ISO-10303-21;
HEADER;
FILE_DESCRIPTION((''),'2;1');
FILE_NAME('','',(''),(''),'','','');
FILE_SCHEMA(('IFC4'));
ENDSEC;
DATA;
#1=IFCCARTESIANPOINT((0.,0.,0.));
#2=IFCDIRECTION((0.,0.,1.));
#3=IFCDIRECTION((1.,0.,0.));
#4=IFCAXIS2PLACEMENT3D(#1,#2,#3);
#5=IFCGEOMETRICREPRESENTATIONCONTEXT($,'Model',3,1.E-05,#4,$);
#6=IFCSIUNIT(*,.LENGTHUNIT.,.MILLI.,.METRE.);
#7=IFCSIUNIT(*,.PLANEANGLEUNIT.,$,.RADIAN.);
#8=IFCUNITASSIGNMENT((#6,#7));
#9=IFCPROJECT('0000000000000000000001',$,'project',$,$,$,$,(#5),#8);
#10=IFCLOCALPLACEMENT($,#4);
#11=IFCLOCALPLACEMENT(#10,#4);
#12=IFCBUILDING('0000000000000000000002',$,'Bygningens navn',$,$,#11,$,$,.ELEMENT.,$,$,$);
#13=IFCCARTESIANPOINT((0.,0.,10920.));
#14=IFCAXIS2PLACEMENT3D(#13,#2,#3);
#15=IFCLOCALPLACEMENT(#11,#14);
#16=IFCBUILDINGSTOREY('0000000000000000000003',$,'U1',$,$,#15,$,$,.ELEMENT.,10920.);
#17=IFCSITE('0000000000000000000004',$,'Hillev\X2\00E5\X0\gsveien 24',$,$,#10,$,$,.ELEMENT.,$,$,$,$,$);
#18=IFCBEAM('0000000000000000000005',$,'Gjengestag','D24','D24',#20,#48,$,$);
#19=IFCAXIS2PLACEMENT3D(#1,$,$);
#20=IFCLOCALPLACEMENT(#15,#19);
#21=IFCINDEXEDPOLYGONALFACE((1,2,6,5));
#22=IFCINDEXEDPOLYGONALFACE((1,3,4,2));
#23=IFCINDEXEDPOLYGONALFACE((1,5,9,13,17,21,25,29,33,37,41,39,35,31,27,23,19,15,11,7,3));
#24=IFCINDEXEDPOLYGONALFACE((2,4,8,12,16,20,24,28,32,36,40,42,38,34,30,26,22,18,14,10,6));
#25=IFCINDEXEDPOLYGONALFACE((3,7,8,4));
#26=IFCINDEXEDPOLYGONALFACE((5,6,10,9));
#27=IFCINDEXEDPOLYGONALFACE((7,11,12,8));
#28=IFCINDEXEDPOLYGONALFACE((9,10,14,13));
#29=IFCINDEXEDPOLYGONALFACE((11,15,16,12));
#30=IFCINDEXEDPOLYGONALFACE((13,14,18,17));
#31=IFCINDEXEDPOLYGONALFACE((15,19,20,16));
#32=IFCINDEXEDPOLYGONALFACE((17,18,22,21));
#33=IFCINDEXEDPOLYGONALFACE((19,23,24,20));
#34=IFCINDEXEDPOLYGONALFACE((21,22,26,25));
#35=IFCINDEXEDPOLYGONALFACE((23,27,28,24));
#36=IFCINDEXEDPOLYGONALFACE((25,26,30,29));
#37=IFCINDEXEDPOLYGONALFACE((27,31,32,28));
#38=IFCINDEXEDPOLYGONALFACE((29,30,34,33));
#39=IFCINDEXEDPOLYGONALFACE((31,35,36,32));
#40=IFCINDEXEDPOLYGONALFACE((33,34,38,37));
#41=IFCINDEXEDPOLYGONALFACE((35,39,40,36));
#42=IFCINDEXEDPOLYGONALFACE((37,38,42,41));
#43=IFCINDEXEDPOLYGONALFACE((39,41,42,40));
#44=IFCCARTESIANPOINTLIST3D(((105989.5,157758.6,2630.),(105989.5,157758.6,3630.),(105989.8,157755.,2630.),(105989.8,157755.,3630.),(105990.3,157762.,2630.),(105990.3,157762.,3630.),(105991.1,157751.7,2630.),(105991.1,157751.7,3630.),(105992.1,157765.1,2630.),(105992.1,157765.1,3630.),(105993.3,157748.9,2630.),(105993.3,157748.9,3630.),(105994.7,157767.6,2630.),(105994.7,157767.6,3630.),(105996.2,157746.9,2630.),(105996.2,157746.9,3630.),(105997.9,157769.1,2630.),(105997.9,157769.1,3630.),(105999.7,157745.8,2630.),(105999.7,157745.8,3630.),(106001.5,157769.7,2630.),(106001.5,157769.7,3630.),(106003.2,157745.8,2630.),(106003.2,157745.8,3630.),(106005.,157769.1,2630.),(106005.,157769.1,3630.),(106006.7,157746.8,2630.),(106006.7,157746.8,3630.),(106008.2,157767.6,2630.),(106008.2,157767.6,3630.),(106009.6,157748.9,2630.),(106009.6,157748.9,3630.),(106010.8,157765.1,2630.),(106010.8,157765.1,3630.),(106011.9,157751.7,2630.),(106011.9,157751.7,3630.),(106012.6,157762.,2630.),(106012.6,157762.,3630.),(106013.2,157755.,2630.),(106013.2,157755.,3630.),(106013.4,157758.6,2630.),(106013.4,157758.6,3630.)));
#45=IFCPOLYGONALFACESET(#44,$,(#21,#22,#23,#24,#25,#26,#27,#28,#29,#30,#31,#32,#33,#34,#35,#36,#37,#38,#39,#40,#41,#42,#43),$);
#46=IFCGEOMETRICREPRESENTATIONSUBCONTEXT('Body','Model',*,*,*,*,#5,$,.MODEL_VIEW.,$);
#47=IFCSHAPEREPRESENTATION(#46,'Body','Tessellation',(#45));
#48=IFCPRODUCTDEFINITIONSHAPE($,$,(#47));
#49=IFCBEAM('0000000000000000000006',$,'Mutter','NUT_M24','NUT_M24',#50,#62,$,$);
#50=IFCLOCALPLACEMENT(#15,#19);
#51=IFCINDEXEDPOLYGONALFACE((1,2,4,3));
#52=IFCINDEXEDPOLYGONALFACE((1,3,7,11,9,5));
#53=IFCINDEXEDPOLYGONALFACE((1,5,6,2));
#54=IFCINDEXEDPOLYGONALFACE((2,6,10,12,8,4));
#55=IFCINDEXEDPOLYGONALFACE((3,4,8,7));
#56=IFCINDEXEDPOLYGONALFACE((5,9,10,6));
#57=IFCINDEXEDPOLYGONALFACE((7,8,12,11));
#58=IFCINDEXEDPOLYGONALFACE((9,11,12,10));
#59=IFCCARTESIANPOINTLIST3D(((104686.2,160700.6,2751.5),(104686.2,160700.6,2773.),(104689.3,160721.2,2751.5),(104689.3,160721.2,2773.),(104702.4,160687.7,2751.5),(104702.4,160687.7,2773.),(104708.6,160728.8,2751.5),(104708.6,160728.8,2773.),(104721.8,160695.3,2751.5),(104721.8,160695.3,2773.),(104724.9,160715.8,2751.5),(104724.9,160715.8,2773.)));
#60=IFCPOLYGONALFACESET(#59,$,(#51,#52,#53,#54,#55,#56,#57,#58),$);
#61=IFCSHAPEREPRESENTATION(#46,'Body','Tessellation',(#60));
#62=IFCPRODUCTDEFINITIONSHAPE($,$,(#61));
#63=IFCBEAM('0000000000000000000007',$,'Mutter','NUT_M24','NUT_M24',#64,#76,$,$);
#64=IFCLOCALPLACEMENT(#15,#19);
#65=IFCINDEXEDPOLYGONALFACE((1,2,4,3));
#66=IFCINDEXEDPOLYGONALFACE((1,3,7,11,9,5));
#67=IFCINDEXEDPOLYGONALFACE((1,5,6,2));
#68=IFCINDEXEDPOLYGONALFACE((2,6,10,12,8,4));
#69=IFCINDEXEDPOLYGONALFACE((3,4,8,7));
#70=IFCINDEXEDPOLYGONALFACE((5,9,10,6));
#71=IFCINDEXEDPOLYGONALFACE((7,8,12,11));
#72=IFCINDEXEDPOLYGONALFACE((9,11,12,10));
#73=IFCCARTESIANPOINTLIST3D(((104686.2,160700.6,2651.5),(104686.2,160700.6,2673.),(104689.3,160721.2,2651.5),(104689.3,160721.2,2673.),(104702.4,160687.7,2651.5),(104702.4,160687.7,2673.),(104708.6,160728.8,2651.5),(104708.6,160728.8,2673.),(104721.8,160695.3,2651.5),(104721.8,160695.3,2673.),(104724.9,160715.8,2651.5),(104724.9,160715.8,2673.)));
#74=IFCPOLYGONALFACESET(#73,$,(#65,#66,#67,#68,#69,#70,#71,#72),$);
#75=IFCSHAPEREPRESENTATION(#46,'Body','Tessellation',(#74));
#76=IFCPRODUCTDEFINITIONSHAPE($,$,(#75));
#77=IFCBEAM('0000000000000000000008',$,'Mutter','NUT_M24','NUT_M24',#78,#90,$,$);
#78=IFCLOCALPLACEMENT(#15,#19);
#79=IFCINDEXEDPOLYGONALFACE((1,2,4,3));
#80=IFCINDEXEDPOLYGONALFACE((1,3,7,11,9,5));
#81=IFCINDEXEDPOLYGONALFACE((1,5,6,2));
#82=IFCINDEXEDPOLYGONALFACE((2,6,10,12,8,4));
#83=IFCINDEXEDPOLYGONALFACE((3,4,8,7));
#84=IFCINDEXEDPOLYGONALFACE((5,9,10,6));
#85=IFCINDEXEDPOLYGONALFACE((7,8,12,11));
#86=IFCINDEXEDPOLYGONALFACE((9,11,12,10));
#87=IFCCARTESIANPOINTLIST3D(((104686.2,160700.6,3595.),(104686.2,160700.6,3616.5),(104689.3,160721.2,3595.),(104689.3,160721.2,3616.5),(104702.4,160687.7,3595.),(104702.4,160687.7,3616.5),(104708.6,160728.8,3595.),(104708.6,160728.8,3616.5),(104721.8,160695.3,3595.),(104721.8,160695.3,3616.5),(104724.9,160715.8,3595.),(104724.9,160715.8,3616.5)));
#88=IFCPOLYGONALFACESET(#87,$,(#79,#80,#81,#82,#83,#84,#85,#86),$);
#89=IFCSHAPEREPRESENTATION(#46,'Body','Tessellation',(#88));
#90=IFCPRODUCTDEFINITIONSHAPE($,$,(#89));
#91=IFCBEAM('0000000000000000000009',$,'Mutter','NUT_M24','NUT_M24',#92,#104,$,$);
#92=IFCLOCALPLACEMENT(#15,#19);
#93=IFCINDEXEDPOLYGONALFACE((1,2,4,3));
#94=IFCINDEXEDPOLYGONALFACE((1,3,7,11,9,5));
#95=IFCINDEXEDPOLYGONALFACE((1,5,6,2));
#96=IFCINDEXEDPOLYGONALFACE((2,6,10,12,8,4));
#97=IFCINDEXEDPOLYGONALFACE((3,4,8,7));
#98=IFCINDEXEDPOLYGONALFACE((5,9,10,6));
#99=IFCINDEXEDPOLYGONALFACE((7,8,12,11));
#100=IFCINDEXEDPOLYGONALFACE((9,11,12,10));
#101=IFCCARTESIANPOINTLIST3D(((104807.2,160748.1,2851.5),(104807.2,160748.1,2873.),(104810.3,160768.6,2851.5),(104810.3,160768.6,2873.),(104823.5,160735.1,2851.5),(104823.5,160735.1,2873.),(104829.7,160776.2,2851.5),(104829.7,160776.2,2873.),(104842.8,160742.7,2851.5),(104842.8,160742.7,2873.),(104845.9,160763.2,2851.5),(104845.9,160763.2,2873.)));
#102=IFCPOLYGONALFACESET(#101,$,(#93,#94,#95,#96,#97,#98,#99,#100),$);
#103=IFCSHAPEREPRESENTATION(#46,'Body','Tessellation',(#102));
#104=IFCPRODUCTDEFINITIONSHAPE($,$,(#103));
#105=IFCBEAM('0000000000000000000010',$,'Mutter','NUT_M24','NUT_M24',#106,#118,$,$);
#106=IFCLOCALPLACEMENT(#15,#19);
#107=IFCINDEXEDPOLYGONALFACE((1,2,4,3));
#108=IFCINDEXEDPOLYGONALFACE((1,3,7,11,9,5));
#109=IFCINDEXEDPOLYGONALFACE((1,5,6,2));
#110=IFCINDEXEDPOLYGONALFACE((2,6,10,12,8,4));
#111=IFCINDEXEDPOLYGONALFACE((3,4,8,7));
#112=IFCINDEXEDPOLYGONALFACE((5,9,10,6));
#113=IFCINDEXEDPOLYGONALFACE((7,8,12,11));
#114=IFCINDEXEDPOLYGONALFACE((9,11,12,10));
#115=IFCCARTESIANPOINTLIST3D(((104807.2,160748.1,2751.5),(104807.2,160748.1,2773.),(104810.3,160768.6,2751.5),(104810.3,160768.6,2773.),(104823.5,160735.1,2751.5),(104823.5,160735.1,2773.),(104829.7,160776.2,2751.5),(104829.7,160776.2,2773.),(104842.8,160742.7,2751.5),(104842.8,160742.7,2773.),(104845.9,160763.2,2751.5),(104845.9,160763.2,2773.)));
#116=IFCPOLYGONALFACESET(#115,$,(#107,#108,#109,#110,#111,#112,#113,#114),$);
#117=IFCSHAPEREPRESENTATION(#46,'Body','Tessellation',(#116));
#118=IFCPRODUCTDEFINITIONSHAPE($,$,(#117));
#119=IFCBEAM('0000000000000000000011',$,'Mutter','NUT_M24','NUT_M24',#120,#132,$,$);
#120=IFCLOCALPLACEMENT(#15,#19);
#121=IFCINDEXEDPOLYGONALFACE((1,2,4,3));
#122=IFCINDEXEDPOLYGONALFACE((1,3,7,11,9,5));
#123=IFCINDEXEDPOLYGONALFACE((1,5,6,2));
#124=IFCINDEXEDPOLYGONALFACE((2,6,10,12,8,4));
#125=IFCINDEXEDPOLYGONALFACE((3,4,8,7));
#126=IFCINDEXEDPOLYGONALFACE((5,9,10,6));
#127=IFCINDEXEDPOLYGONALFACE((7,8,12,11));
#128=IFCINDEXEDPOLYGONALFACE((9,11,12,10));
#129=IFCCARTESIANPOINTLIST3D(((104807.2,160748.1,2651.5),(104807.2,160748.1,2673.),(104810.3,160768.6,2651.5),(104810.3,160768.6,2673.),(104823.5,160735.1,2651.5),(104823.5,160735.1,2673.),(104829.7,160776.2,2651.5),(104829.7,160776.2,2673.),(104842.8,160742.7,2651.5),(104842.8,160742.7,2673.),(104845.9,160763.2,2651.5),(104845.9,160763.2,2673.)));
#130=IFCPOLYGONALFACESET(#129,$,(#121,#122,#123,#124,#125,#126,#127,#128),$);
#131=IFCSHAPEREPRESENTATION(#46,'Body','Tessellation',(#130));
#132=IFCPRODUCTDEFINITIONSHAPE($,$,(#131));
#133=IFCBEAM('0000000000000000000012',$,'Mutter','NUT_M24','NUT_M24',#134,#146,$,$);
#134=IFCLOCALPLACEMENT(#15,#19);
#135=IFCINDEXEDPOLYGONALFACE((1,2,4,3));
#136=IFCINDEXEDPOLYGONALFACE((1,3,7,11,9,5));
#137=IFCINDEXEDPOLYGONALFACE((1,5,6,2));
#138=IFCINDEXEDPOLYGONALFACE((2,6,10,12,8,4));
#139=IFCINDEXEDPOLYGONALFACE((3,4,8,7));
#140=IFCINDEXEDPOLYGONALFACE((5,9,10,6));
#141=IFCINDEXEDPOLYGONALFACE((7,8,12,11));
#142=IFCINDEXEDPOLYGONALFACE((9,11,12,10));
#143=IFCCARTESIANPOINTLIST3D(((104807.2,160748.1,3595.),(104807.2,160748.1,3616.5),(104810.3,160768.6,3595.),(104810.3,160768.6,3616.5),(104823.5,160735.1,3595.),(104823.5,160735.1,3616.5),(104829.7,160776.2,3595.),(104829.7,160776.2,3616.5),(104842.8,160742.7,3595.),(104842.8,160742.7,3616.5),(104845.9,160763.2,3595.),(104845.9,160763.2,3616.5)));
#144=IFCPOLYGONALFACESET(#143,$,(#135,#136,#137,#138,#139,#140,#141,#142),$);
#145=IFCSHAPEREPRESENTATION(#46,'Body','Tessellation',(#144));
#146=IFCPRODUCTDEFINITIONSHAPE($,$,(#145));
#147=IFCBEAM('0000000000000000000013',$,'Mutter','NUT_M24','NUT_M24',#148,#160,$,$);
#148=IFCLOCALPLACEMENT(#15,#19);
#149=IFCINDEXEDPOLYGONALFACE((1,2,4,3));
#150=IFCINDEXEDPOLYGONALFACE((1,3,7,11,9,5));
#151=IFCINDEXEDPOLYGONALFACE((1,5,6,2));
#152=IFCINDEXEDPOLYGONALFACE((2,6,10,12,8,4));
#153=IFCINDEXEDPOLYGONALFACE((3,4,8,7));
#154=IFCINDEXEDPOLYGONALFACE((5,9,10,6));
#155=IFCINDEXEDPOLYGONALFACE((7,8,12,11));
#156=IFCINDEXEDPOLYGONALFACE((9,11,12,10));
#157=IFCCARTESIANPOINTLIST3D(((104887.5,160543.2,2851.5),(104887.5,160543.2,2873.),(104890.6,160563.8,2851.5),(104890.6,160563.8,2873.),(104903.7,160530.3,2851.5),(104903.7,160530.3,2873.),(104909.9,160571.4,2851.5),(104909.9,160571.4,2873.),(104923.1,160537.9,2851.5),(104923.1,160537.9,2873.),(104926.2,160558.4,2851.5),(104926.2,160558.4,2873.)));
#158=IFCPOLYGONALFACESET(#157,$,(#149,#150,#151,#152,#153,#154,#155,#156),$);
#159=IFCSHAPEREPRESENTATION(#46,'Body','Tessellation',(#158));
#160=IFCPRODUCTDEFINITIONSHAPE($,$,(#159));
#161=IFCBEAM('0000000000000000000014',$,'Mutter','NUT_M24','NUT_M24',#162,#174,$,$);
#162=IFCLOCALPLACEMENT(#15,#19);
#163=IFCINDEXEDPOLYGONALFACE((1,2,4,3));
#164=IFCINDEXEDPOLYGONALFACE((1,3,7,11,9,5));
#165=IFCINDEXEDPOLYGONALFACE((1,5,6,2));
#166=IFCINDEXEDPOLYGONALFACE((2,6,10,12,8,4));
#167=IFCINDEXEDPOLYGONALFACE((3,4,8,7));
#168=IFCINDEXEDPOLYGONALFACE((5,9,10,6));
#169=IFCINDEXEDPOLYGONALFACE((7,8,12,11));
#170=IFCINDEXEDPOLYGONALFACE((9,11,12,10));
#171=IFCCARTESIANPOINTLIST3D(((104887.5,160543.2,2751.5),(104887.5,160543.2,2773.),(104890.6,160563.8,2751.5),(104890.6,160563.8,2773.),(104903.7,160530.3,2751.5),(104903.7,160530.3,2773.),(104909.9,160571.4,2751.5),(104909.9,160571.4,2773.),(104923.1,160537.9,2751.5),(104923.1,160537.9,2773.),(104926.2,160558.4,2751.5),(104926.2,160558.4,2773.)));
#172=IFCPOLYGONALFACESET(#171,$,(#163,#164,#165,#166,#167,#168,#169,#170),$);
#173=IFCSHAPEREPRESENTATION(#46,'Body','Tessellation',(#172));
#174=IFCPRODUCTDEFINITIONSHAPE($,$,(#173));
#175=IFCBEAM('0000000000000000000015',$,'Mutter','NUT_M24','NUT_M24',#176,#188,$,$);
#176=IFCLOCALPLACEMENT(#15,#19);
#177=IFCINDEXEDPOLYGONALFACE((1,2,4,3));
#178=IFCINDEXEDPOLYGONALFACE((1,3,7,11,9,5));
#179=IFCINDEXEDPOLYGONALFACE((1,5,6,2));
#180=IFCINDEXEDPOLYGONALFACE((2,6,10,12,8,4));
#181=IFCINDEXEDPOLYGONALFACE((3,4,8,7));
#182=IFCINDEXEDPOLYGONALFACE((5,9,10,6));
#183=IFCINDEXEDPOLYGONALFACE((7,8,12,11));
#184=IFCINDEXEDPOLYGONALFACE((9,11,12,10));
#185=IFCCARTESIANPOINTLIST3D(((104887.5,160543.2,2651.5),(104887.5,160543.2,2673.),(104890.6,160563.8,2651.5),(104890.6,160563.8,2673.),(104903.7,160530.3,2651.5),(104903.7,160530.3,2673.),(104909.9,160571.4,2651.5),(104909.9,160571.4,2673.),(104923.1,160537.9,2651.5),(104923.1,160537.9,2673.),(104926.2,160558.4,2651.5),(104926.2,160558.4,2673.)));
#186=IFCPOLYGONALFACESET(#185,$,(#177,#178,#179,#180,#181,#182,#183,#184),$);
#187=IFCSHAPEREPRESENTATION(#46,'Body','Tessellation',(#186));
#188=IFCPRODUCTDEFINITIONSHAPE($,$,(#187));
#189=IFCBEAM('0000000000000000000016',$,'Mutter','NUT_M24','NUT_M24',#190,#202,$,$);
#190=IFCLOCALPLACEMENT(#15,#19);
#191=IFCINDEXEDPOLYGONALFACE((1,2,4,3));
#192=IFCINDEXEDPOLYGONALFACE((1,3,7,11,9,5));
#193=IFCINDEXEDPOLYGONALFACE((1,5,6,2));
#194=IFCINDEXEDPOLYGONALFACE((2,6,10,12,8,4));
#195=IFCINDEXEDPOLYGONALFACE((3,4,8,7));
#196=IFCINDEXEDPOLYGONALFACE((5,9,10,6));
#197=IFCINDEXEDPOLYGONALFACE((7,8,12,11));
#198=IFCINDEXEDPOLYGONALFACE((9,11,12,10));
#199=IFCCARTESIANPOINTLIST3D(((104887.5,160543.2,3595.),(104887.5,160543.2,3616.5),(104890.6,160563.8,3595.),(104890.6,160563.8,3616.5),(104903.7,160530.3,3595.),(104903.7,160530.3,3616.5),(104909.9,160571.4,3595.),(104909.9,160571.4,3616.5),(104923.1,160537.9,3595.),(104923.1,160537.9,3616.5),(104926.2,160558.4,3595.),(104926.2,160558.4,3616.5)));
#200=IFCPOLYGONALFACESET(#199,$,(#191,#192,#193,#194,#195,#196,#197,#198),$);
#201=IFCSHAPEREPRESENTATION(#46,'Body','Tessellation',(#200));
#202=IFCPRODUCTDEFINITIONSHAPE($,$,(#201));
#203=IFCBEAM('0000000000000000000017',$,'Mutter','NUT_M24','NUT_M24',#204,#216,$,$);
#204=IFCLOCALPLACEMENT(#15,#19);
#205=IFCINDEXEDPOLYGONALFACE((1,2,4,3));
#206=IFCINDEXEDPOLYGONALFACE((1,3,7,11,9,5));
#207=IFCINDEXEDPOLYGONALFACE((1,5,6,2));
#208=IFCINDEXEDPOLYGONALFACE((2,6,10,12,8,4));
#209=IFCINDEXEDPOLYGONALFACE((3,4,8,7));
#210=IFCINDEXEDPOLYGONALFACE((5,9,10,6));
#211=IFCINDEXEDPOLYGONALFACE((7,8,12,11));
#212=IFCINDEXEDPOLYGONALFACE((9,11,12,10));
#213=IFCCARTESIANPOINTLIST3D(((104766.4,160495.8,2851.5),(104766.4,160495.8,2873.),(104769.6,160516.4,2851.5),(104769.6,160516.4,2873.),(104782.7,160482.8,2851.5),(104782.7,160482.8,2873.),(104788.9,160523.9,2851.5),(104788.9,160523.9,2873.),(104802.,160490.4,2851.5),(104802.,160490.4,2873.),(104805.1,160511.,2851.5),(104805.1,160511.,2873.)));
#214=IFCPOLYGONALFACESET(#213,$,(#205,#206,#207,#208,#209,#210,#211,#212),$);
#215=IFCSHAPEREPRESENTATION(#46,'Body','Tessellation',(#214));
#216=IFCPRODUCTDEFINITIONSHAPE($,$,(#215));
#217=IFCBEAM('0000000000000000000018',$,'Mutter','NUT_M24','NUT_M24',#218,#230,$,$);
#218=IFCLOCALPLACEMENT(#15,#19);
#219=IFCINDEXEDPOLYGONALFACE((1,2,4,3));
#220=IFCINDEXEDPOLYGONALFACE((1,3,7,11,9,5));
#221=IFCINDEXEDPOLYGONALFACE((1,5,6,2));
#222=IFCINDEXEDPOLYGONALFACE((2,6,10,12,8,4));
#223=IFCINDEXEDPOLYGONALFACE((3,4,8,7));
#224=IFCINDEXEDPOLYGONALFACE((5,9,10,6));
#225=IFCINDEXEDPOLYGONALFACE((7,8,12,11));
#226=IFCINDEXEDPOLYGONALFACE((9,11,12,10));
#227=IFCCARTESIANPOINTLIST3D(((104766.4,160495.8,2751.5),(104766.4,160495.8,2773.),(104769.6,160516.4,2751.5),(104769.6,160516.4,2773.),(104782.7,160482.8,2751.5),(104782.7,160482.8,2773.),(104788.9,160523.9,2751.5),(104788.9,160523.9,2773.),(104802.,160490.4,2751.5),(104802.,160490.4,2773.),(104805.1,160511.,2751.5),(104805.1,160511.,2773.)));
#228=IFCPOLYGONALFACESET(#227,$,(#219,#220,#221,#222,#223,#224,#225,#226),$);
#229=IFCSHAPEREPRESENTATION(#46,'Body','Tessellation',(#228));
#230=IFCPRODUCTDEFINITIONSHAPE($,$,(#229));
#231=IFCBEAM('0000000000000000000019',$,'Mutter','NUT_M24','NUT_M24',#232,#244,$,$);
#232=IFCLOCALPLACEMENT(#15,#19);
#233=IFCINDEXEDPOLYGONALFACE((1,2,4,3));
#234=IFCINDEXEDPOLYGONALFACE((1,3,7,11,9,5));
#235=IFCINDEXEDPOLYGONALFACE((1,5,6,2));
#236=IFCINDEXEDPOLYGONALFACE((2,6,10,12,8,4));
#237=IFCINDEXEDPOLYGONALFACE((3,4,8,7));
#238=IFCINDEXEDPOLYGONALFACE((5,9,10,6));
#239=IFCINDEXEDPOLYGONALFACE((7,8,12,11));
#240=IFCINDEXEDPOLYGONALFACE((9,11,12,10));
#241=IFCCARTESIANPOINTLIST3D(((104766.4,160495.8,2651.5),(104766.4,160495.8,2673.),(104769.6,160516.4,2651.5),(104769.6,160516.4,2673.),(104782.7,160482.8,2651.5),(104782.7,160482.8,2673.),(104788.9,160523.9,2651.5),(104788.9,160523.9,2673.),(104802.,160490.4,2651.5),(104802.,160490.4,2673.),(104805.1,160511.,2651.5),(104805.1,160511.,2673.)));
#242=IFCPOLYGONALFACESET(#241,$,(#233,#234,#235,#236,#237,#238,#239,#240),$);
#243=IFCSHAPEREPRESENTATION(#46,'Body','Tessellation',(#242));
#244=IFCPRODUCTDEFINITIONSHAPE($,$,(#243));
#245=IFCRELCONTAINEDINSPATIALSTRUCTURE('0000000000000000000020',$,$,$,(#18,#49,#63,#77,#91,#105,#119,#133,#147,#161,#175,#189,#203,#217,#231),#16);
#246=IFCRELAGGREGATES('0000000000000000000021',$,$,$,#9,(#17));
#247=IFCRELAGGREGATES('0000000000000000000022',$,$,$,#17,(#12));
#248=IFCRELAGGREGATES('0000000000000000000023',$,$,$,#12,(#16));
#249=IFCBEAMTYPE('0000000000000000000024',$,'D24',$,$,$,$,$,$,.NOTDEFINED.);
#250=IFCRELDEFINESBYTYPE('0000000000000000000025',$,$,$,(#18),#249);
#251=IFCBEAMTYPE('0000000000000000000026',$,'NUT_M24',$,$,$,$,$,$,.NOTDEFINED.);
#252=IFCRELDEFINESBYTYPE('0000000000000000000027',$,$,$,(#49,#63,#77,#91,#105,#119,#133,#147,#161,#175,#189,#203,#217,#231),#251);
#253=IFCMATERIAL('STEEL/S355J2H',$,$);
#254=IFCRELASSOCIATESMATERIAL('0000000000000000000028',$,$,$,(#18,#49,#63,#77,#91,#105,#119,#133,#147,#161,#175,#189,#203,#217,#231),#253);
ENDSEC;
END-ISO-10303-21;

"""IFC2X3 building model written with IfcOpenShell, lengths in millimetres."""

from ifc_helpers import new_model, si_unit, frame, frame_2d, origin_with_axes, place, context, subcontext, project, spatial, polyline, circle, outline, extrude, material, type_object, element, save


model = new_model("IFC2X3")

# Units and contexts
model_context = context("Model", 3, precision=1e-05, world=origin_with_axes())
body_context = subcontext(model_context, "Body", "Model", "MODEL_VIEW")
ifc_project = project(units=[si_unit("LENGTHUNIT", "METRE", prefix="MILLI"), si_unit("PLANEANGLEUNIT", "RADIAN")], contexts=[model_context])

# Site, building, storey
site_placement = place(None, origin_with_axes())
site = spatial("IfcSite", under=ifc_project, at=site_placement, Name="Hillevågsveien 24", CompositionType="ELEMENT")
building_placement = place(site_placement, origin_with_axes())
building = spatial("IfcBuilding", under=site, at=building_placement, Name="Bygningens navn", CompositionType="ELEMENT")
storey_placement = place(building_placement, frame((0.0, 0.0, 10920.0), z_axis=(0.0, 0.0, 1.0), x_axis=(1.0, 0.0, 0.0)))
storey = spatial("IfcBuildingStorey", under=building, at=storey_placement, Name="U1", CompositionType="ELEMENT", Elevation=10920.0)

# Beams
ifc_material_1 = material(Name="STEEL/S355J2H")
beam_type_1 = type_object("IfcBeamType", Name="D24", PredefinedType="NOTDEFINED")
for number, where, z_axis, x_axis, name in (
    (1, (106001.5, 157757.7, 3630.0), (-0.364877, 0.931056, 0.0), (0.0, 0.0, -1.0), "Gjengestag"),
):
    element("IfcBeam", number, at=place(storey_placement, frame(where, z_axis=z_axis, x_axis=x_axis)), inside=storey, type_object=beam_type_1, material=ifc_material_1, Name=name, Description="D24", ObjectType="D24", context=body_context, shape_type="SweptSolid", body=[
        extrude(circle(Radius=12.0, at=frame_2d((0.0, 0.0), x_axis=(1.0, 0.0))), frame((1000.0, 0.0, 0.0), z_axis=(-1.0, 0.0, 0.0), x_axis=(0.0, -1.0, 0.0)), (0.0, 0.0, 1.0), 1000.0),
    ])
beam_type_2 = type_object("IfcBeamType", Name="NUT_M24", PredefinedType="NOTDEFINED")
for number, where, z_axis, x_axis, name in (
    (2, (104705.5, 160708.2, 2773.0), (-0.364877, 0.931056, 0.0), (0.0, 0.0, -1.0), "Mutter"),
    (3, (104705.5, 160708.2, 2673.0), (-0.364877, 0.931056, 0.0), (0.0, 0.0, -1.0), "Mutter"),
    (4, (104705.5, 160708.2, 3616.5), (-0.364877, 0.931056, 0.0), (0.0, 0.0, -1.0), "Mutter"),
    (5, (104826.6, 160755.7, 2873.0), (-0.364877, 0.931056, 0.0), (0.0, 0.0, -1.0), "Mutter"),
    (6, (104826.6, 160755.7, 2773.0), (-0.364877, 0.931056, 0.0), (0.0, 0.0, -1.0), "Mutter"),
    (7, (104826.6, 160755.7, 2673.0), (-0.364877, 0.931056, 0.0), (0.0, 0.0, -1.0), "Mutter"),
    (8, (104826.6, 160755.7, 3616.5), (-0.364877, 0.931056, 0.0), (0.0, 0.0, -1.0), "Mutter"),
    (9, (104906.8, 160550.8, 2873.0), (-0.364877, 0.931056, 0.0), (0.0, 0.0, -1.0), "Mutter"),
    (10, (104906.8, 160550.8, 2773.0), (-0.364877, 0.931056, 0.0), (0.0, 0.0, -1.0), "Mutter"),
    (11, (104906.8, 160550.8, 2673.0), (-0.364877, 0.931056, 0.0), (0.0, 0.0, -1.0), "Mutter"),
    (12, (104906.8, 160550.8, 3616.5), (-0.364877, 0.931056, 0.0), (0.0, 0.0, -1.0), "Mutter"),
    (13, (104785.8, 160503.4, 2873.0), (-0.364877, 0.931056, 0.0), (0.0, 0.0, -1.0), "Mutter"),
    (14, (104785.8, 160503.4, 2773.0), (-0.364877, 0.931056, 0.0), (0.0, 0.0, -1.0), "Mutter"),
    (15, (104785.8, 160503.4, 2673.0), (-0.364877, 0.931056, 0.0), (0.0, 0.0, -1.0), "Mutter"),
):
    element("IfcBeam", number, at=place(storey_placement, frame(where, z_axis=z_axis, x_axis=x_axis)), inside=storey, type_object=beam_type_2, material=ifc_material_1, Name=name, Description="NUT_M24", ObjectType="NUT_M24", context=body_context, shape_type="SweptSolid", body=[
        extrude(outline(polyline([(-10.4, 18.0), (10.4, 18.0), (20.8, 0.0), (10.4, -18.0), (-10.4, -18.0), (-20.8, 0.0), (-10.4, 18.0)])), frame((21.5, 0.0, 0.0), z_axis=(-1.0, 0.0, 0.0), x_axis=(0.0, -1.0, 0.0)), (0.0, 0.0, 1.0), 21.5),
    ])

save(model, "model.ifc")
